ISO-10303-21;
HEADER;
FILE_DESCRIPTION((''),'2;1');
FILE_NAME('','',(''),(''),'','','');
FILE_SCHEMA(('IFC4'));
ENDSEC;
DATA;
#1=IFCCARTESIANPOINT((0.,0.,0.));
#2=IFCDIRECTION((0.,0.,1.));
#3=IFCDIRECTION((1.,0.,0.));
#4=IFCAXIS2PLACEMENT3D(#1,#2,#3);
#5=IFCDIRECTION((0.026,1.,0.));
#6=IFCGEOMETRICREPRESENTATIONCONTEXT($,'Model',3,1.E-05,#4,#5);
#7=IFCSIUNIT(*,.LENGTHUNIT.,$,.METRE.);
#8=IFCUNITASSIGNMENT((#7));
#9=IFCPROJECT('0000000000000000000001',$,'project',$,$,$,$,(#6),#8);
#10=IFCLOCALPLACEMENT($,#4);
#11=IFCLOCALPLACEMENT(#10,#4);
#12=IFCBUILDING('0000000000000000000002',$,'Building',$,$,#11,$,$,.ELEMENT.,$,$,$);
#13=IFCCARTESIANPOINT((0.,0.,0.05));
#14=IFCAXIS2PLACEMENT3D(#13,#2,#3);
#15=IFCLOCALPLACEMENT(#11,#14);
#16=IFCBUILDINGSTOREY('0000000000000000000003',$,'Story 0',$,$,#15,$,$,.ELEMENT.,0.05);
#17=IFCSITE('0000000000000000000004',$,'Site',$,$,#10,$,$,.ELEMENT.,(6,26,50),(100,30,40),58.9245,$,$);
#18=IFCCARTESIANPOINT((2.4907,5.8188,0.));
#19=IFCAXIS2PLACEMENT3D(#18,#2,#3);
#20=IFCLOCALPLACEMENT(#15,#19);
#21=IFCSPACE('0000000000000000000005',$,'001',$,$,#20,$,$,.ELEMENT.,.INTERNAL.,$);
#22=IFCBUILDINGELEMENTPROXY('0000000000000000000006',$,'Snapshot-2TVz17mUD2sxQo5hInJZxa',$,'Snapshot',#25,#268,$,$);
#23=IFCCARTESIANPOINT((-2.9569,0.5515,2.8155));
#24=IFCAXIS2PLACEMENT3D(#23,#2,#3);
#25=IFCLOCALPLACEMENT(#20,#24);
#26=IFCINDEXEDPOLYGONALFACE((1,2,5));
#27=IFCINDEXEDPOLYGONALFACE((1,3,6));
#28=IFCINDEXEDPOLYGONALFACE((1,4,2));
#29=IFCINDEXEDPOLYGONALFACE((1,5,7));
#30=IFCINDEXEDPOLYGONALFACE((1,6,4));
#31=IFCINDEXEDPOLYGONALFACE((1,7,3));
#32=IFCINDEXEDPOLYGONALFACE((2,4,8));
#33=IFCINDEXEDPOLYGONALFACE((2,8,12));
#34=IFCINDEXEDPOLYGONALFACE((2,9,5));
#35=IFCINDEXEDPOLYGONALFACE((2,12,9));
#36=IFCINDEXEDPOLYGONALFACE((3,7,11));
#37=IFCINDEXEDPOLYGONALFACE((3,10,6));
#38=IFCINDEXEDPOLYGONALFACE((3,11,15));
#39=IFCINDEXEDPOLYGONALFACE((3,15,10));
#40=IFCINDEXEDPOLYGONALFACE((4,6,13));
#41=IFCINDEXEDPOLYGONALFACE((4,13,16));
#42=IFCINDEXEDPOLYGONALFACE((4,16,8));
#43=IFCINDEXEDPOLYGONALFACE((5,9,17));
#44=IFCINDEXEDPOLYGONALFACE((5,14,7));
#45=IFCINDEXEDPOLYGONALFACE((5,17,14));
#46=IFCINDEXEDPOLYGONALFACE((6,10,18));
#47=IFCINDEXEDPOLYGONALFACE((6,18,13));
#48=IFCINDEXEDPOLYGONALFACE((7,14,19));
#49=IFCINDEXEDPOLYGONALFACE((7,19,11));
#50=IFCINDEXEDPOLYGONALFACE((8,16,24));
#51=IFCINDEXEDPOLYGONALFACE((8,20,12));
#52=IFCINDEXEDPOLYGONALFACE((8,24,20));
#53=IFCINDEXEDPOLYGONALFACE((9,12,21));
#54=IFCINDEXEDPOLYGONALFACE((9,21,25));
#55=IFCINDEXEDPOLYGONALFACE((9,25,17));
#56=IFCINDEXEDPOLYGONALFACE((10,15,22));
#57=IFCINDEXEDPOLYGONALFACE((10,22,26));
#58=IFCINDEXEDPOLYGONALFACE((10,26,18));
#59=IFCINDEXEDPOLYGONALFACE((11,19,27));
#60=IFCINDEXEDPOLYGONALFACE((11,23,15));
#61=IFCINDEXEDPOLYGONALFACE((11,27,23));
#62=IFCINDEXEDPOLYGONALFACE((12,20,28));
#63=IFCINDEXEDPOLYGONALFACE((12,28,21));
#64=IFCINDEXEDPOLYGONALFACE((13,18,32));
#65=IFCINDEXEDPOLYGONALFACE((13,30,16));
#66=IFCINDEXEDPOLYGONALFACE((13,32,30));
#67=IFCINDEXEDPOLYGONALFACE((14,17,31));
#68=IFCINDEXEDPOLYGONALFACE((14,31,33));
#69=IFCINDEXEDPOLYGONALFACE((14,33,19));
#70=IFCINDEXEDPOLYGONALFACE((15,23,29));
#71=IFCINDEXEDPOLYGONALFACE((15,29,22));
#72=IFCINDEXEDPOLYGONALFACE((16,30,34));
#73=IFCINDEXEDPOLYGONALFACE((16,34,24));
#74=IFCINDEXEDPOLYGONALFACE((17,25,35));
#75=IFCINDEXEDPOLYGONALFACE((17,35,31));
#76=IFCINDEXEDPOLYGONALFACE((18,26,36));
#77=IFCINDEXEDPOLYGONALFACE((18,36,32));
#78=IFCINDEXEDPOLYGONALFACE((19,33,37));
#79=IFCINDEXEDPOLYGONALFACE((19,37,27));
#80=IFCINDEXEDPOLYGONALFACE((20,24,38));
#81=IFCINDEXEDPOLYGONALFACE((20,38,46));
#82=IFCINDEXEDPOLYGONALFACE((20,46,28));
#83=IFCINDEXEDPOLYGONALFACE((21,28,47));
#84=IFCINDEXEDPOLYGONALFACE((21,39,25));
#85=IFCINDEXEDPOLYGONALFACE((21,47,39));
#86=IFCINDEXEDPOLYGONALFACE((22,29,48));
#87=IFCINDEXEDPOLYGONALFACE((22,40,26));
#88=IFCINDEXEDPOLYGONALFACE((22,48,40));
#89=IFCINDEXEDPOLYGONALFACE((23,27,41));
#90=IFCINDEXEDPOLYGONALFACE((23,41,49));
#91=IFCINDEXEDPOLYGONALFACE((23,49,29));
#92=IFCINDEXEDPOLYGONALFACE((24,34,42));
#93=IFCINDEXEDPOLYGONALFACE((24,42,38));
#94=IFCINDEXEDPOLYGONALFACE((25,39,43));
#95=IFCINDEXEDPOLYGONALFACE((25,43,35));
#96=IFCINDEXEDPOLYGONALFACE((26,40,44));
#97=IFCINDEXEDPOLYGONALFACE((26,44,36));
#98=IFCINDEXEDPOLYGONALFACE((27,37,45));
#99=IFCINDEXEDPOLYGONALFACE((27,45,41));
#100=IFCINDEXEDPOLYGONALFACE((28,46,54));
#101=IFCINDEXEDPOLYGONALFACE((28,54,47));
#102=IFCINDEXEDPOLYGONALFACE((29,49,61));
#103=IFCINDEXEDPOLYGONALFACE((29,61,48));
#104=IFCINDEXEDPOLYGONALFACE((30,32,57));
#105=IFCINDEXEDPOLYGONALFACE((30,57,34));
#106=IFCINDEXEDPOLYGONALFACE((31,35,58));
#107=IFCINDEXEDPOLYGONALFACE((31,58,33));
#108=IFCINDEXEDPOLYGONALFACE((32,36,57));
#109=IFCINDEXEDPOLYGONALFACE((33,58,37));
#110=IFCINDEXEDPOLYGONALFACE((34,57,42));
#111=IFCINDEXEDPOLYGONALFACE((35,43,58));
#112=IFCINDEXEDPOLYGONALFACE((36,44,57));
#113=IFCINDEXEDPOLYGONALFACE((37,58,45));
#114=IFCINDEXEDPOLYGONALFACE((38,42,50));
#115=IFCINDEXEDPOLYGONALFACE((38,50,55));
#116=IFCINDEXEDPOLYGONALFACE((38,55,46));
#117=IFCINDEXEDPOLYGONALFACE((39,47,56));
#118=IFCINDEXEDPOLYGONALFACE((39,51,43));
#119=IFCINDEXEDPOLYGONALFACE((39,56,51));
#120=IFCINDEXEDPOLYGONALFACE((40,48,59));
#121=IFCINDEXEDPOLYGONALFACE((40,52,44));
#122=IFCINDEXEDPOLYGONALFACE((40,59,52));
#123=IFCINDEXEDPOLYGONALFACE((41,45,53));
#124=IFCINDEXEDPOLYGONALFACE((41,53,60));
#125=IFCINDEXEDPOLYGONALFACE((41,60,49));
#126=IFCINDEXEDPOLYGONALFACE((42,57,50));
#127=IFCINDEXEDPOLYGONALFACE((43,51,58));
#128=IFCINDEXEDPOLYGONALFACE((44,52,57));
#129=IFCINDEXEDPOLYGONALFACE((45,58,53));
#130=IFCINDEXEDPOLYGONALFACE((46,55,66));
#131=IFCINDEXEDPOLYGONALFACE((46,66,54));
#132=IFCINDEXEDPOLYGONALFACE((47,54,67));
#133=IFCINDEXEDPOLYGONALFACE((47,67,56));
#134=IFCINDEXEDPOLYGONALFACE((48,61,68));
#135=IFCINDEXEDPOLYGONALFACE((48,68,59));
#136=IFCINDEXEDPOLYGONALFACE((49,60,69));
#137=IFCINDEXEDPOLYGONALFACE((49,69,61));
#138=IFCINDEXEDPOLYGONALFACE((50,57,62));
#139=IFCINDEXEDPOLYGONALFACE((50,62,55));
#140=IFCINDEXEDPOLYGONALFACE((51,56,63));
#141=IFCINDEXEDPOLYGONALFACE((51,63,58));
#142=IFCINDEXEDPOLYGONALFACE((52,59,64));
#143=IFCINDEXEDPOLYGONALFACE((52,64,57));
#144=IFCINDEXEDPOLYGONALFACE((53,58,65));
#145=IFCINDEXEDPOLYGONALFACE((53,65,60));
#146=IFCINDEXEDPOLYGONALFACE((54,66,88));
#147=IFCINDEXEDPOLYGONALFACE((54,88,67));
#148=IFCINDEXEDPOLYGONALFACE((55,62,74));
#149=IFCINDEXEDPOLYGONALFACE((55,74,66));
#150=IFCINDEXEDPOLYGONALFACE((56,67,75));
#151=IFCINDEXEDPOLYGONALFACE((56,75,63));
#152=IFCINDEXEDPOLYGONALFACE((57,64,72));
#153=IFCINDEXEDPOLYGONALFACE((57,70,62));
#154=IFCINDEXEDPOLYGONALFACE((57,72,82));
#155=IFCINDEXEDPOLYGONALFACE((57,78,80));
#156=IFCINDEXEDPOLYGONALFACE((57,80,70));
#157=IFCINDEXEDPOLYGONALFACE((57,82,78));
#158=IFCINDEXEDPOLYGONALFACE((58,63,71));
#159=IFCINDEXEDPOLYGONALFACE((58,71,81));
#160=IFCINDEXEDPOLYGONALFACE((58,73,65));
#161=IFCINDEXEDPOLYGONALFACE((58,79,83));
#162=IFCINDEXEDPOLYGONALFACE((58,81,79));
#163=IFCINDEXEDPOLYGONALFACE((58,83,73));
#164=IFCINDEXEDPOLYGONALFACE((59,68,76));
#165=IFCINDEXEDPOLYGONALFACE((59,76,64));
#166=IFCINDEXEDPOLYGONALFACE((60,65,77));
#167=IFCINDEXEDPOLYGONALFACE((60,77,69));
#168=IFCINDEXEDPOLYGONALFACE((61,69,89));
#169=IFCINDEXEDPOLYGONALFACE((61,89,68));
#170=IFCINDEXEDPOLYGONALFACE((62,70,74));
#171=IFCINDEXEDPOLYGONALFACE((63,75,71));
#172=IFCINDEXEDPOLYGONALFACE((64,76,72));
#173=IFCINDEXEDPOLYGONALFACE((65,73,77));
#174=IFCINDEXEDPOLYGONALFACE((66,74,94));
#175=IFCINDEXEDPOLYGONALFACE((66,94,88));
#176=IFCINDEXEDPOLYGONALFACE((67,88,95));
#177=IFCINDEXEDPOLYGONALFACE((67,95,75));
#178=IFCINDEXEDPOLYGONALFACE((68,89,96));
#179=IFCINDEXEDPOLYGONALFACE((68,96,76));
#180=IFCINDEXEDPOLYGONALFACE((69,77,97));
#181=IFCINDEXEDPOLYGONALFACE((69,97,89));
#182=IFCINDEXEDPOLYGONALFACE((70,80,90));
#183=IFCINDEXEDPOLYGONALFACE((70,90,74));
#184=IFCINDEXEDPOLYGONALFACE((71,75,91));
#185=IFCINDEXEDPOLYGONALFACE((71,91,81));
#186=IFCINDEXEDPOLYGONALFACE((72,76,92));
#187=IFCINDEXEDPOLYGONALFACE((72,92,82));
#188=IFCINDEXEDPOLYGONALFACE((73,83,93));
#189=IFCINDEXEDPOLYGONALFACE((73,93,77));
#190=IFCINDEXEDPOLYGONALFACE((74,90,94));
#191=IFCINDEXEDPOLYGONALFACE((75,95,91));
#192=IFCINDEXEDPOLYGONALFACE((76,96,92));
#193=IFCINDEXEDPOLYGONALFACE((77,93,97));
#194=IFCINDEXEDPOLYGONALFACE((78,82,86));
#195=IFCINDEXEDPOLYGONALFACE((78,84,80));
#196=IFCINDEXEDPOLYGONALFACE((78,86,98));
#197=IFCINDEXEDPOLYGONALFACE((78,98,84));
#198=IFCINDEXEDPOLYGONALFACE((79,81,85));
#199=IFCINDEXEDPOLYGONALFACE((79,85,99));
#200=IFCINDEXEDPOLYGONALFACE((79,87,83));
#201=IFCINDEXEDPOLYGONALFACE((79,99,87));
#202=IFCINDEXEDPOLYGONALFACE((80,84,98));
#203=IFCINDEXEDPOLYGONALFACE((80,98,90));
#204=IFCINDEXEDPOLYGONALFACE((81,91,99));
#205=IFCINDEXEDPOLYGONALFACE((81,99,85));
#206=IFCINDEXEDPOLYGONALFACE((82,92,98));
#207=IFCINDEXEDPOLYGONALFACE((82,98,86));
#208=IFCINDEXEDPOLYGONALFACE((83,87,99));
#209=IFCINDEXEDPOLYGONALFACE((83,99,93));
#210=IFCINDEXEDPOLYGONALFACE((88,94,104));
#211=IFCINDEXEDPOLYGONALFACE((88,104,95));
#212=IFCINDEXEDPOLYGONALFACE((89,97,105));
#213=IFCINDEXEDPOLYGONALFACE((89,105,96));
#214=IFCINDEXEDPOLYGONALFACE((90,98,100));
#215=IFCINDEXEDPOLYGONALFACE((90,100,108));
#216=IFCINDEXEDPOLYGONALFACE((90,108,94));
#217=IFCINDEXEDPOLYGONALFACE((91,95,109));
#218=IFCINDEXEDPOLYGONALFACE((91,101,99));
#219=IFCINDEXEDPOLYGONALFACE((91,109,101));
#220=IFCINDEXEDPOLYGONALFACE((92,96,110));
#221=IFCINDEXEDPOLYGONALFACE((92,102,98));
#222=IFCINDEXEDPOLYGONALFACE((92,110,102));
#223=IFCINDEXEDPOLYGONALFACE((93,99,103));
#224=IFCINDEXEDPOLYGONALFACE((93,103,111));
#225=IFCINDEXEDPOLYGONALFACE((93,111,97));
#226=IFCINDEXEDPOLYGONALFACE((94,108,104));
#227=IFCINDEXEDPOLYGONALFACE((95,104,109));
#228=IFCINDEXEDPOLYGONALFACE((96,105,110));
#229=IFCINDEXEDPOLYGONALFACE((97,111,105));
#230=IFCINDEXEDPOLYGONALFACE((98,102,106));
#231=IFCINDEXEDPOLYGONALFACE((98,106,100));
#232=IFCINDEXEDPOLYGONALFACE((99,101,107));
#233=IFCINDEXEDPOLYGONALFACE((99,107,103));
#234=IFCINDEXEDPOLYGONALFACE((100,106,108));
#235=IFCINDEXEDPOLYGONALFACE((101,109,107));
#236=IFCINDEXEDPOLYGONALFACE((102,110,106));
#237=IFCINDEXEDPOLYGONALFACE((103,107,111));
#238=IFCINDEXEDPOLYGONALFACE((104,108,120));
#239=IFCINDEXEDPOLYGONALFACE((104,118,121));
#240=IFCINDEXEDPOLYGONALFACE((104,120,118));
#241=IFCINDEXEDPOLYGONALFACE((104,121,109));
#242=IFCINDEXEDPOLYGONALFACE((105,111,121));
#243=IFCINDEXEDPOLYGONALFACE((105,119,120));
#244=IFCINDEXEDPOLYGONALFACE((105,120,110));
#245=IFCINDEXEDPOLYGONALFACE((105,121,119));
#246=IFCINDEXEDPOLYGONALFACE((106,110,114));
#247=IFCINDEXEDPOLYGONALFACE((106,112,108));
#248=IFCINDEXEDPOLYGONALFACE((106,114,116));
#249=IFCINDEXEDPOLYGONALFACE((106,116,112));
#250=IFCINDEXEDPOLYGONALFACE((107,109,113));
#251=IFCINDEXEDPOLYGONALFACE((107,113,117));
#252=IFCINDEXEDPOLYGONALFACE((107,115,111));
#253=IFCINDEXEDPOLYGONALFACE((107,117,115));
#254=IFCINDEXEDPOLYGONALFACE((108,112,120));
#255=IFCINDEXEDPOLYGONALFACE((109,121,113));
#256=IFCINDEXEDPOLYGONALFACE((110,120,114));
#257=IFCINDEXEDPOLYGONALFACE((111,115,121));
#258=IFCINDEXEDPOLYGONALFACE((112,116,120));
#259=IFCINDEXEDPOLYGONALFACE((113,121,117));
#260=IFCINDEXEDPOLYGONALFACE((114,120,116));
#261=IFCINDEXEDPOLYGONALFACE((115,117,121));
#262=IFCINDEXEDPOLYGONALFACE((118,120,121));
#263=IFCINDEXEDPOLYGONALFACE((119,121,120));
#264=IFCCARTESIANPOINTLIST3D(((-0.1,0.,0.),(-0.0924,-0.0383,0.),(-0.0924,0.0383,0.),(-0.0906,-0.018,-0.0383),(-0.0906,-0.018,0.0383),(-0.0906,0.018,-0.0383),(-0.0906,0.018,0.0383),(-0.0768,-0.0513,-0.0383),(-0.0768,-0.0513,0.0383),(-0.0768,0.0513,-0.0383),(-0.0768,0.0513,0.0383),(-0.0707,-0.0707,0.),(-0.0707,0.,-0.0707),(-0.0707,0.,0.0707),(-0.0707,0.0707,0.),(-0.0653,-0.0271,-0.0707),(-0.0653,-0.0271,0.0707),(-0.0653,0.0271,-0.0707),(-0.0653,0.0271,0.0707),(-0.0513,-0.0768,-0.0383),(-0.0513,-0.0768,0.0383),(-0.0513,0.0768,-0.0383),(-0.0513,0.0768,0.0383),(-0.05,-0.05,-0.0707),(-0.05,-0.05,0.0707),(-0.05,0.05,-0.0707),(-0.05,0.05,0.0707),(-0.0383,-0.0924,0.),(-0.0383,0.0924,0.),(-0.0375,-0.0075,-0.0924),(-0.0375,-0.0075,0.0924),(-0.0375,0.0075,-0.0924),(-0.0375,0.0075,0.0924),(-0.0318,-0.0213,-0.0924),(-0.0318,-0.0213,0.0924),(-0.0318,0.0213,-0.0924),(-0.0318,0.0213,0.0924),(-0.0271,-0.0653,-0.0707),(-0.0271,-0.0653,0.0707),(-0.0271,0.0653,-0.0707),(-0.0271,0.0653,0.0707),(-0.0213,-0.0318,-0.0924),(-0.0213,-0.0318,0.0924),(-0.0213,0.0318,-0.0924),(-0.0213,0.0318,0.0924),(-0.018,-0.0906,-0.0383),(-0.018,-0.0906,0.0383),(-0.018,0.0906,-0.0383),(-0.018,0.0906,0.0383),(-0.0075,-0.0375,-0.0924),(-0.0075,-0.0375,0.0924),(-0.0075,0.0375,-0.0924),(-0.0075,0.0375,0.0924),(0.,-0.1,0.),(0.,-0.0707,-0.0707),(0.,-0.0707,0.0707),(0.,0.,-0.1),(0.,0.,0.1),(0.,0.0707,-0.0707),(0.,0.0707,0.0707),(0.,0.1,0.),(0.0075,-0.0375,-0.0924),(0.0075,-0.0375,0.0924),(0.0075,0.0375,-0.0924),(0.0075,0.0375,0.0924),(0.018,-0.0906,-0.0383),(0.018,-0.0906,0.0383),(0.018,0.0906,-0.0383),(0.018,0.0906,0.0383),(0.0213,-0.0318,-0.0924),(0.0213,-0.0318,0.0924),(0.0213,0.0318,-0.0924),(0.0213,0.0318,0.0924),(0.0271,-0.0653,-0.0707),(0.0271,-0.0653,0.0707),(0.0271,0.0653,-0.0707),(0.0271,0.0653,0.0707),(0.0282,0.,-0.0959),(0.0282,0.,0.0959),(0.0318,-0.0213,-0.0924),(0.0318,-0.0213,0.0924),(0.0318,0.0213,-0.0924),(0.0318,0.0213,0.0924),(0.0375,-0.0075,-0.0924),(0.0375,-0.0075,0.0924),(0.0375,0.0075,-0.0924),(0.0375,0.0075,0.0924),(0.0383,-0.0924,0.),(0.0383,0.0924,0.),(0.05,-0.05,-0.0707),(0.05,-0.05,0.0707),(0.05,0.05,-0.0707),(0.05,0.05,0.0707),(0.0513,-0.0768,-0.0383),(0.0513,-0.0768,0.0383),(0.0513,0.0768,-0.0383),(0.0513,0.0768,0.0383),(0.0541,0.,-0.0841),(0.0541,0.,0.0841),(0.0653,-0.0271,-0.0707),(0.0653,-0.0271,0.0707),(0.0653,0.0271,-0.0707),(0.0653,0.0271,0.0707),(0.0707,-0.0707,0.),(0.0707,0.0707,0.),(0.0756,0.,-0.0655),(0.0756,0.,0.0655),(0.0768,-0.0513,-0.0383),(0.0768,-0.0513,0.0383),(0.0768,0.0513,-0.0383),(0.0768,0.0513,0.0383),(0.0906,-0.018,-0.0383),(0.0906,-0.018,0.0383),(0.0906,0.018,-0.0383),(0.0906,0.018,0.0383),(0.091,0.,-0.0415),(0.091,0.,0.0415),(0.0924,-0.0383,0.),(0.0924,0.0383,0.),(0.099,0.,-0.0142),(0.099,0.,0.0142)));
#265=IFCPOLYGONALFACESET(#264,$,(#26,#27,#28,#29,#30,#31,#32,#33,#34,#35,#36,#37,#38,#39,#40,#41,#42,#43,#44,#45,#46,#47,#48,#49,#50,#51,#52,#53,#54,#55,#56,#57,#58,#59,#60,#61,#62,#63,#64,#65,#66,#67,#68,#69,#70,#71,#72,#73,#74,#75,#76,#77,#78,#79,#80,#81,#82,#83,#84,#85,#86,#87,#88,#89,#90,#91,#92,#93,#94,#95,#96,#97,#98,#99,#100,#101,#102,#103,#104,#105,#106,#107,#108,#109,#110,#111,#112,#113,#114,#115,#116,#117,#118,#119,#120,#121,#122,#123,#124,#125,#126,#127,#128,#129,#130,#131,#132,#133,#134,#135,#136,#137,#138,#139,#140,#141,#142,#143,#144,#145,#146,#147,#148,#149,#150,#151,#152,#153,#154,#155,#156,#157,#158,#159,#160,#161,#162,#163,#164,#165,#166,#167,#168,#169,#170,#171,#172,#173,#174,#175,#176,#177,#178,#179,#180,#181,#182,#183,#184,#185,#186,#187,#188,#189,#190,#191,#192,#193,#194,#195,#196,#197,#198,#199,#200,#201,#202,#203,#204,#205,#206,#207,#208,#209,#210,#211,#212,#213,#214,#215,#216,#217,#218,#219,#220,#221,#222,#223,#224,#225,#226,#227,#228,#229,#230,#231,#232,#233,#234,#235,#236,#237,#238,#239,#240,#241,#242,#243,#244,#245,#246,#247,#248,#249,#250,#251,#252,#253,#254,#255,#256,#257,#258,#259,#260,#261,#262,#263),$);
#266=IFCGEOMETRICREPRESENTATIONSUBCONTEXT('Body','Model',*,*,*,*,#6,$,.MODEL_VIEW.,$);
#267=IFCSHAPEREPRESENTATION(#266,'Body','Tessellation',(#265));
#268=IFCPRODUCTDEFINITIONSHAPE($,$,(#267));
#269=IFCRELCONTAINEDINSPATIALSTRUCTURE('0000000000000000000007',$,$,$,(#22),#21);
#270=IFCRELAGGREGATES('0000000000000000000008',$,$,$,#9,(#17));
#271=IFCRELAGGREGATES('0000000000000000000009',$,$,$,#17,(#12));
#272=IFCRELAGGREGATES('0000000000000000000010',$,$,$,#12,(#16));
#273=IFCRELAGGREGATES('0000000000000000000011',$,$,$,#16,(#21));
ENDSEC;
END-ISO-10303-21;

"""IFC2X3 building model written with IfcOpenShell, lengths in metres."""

from ifc_helpers import new_model, entity, si_unit, direction, frame, origin_with_axes, place, context, subcontext, project, spatial, element, save


model = new_model("IFC2X3")

# Units and contexts
model_context = context("Model", 3, precision=1e-05, world=origin_with_axes(), true_north=direction((0.026, 1.0, 0.0)))
body_context = subcontext(model_context, "Body", "Model", "MODEL_VIEW")
ifc_project = project(units=[si_unit("LENGTHUNIT", "METRE")], contexts=[model_context])

# Site, building, storey
site_placement = place(None, origin_with_axes())
site = spatial("IfcSite", under=ifc_project, at=site_placement, Name="Site", CompositionType="ELEMENT", RefLatitude=(6, 26, 50), RefLongitude=(100, 30, 40), RefElevation=58.9245)
building_placement = place(site_placement, origin_with_axes())
building = spatial("IfcBuilding", under=site, at=building_placement, Name="Building", CompositionType="ELEMENT")
storey_placement = place(building_placement, frame((0.0, 0.0, 0.05), z_axis=(0.0, 0.0, 1.0), x_axis=(1.0, 0.0, 0.0)))
storey = spatial("IfcBuildingStorey", under=building, at=storey_placement, Name="Story 0", CompositionType="ELEMENT", Elevation=0.05)

# Shared definitions
space_placement = place(storey_placement, frame((2.4907, 5.8188, 0.0), z_axis=(0.0, 0.0, 1.0), x_axis=(1.0, 0.0, 0.0)))
space = spatial("IfcSpace", under=storey, at=space_placement, Name="001", CompositionType="ELEMENT", InteriorOrExteriorSpace="INTERNAL")

# Building element proxy
for number, where, z_axis, x_axis, name in (
    (1, (-2.9569, 0.5515, 2.8155), (0.0, 0.0, 1.0), (1.0, 0.0, 0.0), "Snapshot-2TVz17mUD2sxQo5hInJZxa"),
):
    element("IfcBuildingElementProxy", number, at=place(space_placement, frame(where, z_axis=z_axis, x_axis=x_axis)), inside=space, Name=name, ObjectType="Snapshot", context=body_context, shape_type="CSG", body=[
        entity("IfcSphere", entity("IfcAxis2Placement3D", entity("IfcCartesianPoint", [0.0, 0.0, 0.0]), entity("IfcDirection", [0.0, 0.0, 1.0]), entity("IfcDirection", [1.0, 0.0, 0.0])), 0.1),
    ])

save(model, "model.ifc")
